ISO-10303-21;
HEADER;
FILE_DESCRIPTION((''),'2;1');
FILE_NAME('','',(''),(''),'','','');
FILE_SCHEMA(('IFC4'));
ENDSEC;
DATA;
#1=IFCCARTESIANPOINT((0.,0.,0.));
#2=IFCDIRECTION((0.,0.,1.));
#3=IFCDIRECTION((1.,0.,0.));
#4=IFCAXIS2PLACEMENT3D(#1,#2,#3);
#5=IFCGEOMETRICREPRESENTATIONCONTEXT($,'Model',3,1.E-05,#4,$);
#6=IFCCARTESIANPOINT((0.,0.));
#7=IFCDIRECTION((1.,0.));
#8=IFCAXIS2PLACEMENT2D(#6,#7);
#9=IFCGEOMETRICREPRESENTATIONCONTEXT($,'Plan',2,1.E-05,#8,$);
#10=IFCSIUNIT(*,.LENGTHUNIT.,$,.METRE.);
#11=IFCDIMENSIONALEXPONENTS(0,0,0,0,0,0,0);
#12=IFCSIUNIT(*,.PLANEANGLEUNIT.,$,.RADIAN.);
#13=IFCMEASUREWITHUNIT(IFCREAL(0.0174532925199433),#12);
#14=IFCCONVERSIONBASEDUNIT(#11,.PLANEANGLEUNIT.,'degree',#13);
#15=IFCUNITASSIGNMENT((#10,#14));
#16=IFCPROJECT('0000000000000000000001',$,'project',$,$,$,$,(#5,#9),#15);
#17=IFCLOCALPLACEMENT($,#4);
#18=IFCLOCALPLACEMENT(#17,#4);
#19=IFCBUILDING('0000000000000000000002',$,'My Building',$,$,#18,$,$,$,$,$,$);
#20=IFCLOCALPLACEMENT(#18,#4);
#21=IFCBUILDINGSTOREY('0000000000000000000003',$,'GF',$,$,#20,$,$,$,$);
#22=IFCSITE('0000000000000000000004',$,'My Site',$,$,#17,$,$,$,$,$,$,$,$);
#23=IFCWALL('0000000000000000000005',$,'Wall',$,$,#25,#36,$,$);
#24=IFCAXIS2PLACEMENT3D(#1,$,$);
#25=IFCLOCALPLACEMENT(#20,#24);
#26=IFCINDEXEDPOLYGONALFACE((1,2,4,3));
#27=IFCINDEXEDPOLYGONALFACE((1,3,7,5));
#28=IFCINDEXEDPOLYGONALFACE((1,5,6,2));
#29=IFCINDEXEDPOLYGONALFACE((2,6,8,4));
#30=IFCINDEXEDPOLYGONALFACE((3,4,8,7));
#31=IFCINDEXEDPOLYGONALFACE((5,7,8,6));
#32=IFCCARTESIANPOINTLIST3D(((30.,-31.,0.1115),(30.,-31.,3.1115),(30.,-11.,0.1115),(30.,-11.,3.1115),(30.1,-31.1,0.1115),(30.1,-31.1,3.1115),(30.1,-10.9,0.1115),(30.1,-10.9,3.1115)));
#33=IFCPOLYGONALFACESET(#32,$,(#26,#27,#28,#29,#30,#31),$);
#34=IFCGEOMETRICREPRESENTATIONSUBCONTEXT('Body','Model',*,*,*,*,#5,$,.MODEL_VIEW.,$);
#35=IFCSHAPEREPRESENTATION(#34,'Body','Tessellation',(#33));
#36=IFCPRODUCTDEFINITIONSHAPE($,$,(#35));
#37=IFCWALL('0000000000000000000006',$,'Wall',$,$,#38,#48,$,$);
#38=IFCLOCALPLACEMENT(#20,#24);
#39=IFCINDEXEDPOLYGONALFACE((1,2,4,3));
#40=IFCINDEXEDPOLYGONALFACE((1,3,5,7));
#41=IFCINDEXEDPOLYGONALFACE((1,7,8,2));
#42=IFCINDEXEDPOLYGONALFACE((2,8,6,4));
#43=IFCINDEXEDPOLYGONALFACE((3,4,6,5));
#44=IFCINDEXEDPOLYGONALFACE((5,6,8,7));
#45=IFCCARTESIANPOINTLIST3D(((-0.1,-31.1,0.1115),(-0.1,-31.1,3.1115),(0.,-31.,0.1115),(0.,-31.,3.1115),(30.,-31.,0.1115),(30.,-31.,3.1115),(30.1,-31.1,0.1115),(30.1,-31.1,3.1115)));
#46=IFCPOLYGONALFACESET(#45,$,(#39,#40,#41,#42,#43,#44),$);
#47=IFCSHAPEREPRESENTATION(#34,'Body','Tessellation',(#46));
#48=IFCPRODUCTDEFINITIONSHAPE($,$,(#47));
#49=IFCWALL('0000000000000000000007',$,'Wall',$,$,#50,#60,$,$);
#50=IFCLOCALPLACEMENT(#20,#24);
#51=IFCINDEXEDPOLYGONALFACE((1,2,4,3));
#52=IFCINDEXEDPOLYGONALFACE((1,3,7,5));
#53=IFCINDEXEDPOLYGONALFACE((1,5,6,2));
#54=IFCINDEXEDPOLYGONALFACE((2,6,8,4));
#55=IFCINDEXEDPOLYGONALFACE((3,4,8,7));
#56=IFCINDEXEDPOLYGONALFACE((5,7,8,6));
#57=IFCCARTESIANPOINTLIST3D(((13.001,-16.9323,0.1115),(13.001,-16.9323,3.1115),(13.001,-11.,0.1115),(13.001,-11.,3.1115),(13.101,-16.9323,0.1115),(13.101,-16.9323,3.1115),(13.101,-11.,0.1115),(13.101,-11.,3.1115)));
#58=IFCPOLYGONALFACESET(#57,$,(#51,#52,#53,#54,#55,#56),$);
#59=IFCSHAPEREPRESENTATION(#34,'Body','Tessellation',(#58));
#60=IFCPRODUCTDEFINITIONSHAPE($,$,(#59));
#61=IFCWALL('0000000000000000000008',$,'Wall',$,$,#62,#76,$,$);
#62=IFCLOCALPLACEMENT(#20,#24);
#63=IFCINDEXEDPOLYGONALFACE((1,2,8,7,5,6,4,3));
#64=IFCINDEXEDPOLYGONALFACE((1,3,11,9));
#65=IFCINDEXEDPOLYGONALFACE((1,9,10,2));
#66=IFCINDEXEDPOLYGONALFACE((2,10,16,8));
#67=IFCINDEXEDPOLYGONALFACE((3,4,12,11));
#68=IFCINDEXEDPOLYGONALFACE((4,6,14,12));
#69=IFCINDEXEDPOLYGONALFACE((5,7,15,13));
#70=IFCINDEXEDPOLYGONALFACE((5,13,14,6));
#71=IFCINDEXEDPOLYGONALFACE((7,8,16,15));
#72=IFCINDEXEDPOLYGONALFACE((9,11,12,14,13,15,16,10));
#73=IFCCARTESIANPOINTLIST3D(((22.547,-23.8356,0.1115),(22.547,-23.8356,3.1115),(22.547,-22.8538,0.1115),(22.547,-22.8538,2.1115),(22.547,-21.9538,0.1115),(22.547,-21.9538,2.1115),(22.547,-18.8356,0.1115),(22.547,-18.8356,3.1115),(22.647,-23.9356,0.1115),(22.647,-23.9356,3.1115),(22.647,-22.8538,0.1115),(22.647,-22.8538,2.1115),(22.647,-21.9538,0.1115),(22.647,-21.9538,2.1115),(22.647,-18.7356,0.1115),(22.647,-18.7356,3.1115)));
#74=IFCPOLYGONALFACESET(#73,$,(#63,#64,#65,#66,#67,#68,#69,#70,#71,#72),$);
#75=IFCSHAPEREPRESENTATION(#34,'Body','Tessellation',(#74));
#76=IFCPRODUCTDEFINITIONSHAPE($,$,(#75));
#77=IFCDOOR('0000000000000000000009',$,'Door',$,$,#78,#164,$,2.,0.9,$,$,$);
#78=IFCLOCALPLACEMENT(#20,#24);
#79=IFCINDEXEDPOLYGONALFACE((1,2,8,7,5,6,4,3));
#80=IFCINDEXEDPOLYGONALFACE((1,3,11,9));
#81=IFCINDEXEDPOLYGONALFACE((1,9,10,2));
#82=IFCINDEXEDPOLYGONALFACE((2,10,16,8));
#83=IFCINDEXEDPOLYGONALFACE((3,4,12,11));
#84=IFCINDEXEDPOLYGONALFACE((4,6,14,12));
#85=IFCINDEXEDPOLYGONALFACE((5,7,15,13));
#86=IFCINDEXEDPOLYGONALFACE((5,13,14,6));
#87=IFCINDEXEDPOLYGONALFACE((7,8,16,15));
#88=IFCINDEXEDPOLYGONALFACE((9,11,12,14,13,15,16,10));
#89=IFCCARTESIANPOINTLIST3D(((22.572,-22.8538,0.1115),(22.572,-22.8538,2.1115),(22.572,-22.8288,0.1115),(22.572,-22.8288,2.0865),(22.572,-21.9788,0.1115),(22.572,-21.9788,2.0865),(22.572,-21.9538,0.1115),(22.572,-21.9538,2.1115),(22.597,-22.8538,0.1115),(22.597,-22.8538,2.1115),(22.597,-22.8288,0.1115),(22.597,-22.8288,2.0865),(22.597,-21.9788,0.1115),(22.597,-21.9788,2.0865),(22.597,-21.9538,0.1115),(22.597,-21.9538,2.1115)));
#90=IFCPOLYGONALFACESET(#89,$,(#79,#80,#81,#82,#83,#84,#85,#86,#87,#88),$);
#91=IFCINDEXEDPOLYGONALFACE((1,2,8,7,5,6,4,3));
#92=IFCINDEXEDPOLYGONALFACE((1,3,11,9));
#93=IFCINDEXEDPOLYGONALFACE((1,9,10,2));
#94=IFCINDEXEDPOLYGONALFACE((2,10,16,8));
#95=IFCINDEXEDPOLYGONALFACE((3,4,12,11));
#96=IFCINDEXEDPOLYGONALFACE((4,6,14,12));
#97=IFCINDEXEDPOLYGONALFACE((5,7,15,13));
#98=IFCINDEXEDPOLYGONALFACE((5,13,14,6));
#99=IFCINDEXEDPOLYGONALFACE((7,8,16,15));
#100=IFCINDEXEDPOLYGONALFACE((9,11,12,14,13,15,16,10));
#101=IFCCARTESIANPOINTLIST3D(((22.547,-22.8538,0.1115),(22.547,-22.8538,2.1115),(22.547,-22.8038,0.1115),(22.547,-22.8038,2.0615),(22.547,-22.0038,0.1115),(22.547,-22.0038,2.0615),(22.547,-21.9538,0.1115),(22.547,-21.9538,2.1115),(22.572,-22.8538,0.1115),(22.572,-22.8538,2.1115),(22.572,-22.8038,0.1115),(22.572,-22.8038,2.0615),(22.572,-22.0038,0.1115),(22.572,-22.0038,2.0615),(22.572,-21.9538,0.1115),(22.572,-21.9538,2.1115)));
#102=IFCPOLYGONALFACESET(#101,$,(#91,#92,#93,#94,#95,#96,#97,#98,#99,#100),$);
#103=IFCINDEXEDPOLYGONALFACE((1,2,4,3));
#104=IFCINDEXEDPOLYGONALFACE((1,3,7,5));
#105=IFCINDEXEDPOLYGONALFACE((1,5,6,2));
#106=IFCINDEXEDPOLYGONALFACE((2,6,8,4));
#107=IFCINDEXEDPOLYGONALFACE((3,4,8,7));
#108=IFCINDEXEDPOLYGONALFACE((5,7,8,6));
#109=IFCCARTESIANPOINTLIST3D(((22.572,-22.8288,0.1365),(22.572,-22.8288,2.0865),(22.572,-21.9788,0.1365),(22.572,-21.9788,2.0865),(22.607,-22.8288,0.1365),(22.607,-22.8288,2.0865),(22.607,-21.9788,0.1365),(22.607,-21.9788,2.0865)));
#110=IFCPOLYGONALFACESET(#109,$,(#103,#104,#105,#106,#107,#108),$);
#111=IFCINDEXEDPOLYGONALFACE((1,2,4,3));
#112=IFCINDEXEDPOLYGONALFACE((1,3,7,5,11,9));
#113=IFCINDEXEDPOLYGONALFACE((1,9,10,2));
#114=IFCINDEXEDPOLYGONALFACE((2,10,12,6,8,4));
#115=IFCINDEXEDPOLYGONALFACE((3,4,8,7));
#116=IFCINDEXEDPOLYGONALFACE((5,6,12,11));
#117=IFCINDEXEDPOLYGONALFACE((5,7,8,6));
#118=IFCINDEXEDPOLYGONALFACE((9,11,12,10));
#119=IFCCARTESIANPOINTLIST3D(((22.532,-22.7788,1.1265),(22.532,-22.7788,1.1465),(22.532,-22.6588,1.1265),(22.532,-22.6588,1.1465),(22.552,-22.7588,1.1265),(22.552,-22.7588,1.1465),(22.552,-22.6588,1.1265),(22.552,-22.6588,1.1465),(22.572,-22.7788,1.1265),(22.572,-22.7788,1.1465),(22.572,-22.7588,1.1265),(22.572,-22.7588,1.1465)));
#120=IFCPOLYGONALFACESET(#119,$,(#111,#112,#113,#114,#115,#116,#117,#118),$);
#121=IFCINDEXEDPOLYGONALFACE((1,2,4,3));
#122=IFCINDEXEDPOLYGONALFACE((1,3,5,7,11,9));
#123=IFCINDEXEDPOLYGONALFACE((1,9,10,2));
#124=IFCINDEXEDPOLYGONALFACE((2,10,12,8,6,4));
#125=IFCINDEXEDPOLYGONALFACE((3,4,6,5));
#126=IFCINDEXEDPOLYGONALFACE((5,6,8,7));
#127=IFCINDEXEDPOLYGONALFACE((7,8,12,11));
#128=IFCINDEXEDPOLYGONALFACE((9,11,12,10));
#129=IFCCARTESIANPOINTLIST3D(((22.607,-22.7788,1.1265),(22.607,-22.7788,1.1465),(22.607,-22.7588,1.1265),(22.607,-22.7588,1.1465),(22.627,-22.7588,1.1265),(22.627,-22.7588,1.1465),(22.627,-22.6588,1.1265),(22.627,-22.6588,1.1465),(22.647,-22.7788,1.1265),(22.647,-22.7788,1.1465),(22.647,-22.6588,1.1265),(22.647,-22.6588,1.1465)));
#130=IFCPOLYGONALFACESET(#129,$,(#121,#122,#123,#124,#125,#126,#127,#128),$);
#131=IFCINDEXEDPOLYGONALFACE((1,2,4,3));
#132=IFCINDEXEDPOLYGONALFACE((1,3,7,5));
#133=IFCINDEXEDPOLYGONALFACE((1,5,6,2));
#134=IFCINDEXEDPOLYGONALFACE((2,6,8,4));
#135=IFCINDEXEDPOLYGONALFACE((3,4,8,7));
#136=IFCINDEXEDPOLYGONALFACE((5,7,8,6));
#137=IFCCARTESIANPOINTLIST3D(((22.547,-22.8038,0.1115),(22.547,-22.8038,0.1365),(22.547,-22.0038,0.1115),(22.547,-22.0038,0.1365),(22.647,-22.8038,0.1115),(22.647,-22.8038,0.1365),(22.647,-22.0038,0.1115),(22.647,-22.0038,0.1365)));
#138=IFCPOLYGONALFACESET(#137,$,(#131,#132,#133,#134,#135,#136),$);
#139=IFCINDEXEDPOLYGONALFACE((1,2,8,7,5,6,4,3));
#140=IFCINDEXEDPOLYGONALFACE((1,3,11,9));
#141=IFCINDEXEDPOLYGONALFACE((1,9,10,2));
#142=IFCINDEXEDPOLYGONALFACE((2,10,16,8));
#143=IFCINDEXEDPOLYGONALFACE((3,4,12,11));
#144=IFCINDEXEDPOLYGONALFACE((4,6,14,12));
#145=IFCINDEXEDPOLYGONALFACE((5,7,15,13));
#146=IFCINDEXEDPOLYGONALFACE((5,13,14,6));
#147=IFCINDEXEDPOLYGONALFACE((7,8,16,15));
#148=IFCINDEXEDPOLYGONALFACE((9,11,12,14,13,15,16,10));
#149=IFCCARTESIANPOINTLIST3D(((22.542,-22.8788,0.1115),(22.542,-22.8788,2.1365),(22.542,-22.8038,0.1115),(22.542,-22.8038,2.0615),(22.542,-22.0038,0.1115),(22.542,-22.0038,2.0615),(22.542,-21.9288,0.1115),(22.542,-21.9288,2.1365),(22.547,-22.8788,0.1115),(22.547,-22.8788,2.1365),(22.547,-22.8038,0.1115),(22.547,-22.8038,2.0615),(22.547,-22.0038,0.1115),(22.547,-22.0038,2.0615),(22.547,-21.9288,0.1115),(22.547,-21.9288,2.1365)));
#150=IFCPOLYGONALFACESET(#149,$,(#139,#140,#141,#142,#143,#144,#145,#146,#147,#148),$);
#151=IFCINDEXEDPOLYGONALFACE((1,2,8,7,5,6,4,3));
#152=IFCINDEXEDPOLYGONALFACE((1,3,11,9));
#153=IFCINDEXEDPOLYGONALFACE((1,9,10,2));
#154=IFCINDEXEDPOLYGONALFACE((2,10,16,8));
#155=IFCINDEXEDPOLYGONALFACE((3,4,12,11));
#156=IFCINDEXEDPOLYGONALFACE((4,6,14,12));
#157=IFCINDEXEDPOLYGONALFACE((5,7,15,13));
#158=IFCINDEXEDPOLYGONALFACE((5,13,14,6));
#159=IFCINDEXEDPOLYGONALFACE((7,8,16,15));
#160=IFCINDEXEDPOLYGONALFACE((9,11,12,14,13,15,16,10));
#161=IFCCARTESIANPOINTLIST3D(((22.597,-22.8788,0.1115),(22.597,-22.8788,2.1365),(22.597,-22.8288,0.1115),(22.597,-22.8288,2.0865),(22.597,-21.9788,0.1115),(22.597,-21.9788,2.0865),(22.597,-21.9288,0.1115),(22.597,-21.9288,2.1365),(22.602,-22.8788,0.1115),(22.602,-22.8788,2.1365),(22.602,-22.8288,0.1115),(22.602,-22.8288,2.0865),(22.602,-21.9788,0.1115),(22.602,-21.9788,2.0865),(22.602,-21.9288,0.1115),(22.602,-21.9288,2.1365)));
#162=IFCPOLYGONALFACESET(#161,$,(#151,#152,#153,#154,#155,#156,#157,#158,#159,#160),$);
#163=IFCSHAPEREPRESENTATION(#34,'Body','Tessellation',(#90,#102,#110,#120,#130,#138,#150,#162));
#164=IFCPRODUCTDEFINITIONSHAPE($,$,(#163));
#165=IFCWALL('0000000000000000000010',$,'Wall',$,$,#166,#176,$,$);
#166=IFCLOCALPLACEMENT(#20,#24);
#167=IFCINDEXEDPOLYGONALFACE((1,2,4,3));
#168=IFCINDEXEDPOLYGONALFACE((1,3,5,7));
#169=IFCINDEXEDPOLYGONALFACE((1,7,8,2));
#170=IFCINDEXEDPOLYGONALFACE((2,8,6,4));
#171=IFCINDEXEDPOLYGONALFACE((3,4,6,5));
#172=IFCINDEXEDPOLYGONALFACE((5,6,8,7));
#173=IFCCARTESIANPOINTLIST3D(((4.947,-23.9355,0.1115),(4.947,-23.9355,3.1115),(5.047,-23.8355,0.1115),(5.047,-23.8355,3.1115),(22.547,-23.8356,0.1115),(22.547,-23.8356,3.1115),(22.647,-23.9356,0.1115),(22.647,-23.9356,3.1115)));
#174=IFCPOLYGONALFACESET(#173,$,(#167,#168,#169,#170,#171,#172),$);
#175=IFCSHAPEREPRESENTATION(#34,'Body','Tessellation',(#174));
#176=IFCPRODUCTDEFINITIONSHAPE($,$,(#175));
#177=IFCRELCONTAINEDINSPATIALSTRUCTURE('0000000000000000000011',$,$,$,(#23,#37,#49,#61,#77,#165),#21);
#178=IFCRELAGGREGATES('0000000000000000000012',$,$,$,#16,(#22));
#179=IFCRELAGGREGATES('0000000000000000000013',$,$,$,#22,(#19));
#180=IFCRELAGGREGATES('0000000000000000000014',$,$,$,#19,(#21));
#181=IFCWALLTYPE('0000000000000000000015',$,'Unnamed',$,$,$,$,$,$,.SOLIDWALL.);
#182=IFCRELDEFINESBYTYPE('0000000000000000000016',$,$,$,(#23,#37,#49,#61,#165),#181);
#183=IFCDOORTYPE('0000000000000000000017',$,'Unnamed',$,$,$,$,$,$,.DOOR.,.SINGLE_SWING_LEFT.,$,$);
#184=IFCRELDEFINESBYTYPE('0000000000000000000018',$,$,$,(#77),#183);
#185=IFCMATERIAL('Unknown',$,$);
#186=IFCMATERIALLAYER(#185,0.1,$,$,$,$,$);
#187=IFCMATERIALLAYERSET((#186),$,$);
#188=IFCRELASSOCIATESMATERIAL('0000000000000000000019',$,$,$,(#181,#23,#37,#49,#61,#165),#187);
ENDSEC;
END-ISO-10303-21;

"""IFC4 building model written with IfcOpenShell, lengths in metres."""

from ifc_helpers import new_model, entity, si_unit, converted_unit, frame, origin_with_axes, origin_2d_with_axis, place, context, subcontext, project, spatial, line, indexed_curve, outline, extrude, shape, source, transform, mapped, material, layer, layer_set, layer_usage, type_object, type_shapes, element, fill, save


model = new_model("IFC4")

# Units and contexts
model_context = context("Model", 3, precision=1e-05, world=origin_with_axes())
plan_context = context("Plan", 2, precision=1e-05, world=origin_2d_with_axis())
body_context_1 = subcontext(model_context, "Body", "Model", "MODEL_VIEW")
body_context_2 = subcontext(plan_context, "Body", "Plan", "PLAN_VIEW")
ifc_project = project(units=[si_unit("LENGTHUNIT", "METRE"), converted_unit("PLANEANGLEUNIT", "degree", entity("IfcReal", 0.0174532925199433), si_unit("PLANEANGLEUNIT", "RADIAN"), dimensions=[0, 0, 0, 0, 0, 0, 0])], contexts=[model_context, plan_context])

# Site, building, storey
site_placement = place(None, origin_with_axes())
site = spatial("IfcSite", under=ifc_project, at=site_placement, Name="My Site")
building_placement = place(site_placement, origin_with_axes())
building = spatial("IfcBuilding", under=site, at=building_placement, Name="My Building")
storey_placement = place(building_placement, origin_with_axes())
storey = spatial("IfcBuildingStorey", under=building, at=storey_placement, Name="GF")

# Walls
ifc_material = material(Name="Unknown")
ifc_layer = layer(ifc_material, 0.1)
ifc_layer_set = layer_set([ifc_layer])
ifc_layer_usage_1 = layer_usage(ifc_layer_set, "AXIS2", "POSITIVE", 0.0)
wall_type = type_object("IfcWallType", Name="Unnamed", PredefinedType="SOLIDWALL", material=ifc_layer_set)
wall_1_placement = place(storey_placement, frame((30.0, -11.0, 0.1115), z_axis=(0.0, 0.0, 1.0), x_axis=(0.0, -1.0, 0.0)))
element("IfcWall", 1, at=wall_1_placement, inside=storey, type_object=wall_type, material=ifc_layer_usage_1, Name="Wall", context=body_context_1, shape_type="SweptSolid", body=[
    extrude(outline(indexed_curve([(0.0, 0.0), (-0.1, 0.1), (20.1, 0.1), (20.0, 0.0)], segments=[line(1, 2, 3, 4, 1)])), origin_with_axes(), (0.0, 0.0, 1.0), 3.0),
])
ifc_layer_usage_2 = layer_usage(ifc_layer_set, "AXIS2", "POSITIVE", 0.0)
wall_2_placement = place(storey_placement, frame((30.0, -31.0, 0.1115), z_axis=(0.0, 0.0, 1.0), x_axis=(-1.0, 0.0, 0.0)))
element("IfcWall", 2, at=wall_2_placement, inside=storey, type_object=wall_type, material=ifc_layer_usage_2, Name="Wall", context=body_context_1, shape_type="SweptSolid", body=[
    extrude(outline(indexed_curve([(0.0, 0.0), (-0.1, 0.1), (30.1, 0.1), (30.0, 0.0)], segments=[line(1, 2, 3, 4, 1)])), origin_with_axes(), (0.0, 0.0, 1.0), 3.0),
])
ifc_layer_usage_3 = layer_usage(ifc_layer_set, "AXIS2", "POSITIVE", 0.0)
wall_3_placement = place(storey_placement, frame((13.101, -16.9323, 0.1115), z_axis=(0.0, 0.0, 1.0), x_axis=(0.0, 1.0, 0.0)))
element("IfcWall", 3, at=wall_3_placement, inside=storey, type_object=wall_type, material=ifc_layer_usage_3, Name="Wall", context=body_context_1, shape_type="SweptSolid", body=[
    extrude(outline(indexed_curve([(0.0, 0.0), (0.0, 0.1), (5.9323, 0.1), (5.9323, 0.0)], segments=[line(1, 2, 3, 4, 1)])), origin_with_axes(), (0.0, 0.0, 1.0), 3.0),
])

# Wall, opening, door
ifc_layer_usage_4 = layer_usage(ifc_layer_set, "AXIS2", "POSITIVE", 0.0)
wall_4_placement = place(storey_placement, frame((22.547, -18.8356, 0.1115), z_axis=(0.0, 0.0, 1.0), x_axis=(0.0, -1.0, 0.0)))
wall_4 = element("IfcWall", 4, at=wall_4_placement, inside=storey, type_object=wall_type, material=ifc_layer_usage_4, Name="Wall", context=body_context_1, shape_type="SweptSolid", body=[
    extrude(outline(indexed_curve([(0.0, 0.0), (-0.1, 0.1), (5.1, 0.1), (5.0, 0.0)], segments=[line(1, 2, 3, 4, 1)])), origin_with_axes(), (0.0, 0.0, 1.0), 3.0),
])
shared_shape_1 = source(origin_with_axes(), body_context_1, "Body", "SweptSolid", [
    extrude(outline(indexed_curve([(0.0, 0.0), (0.9, 0.0), (0.9, 2.0), (0.0, 2.0)], segments=[line(1, 2, 3, 4, 1)])), frame((0.0, -0.6, 0.0), z_axis=(0.0, -1.0, 0.0), x_axis=(1.0, 0.0, 0.0)), (0.0, 0.0, -1.0), 1.2),
])
opening_1_placement = place(wall_4_placement, frame((3.1182, 0.0, 0.0), z_axis=(0.0, 0.0, 1.0), x_axis=(1.0, 0.0, 0.0)))
opening_1 = element("IfcOpeningElement", 5, at=opening_1_placement, cuts=wall_4, PredefinedType="OPENING", context=body_context_1, shape_type="MappedRepresentation", body=[
    mapped(shared_shape_1, transform((0.0, 0.0, 0.0), x_axis=(1.0, 0.0, 0.0), y_axis=(0.0, 1.0, 0.0), z_axis=(0.0, 0.0, 1.0), scale=1.0)),
])
door_type = type_object("IfcDoorType", Name="Unnamed", OperationType="SINGLE_SWING_LEFT", PredefinedType="DOOR")
shared_shape_2 = source(origin_with_axes(), body_context_1, "Body", "SweptSolid", [
    extrude(outline(indexed_curve([(0.0, 0.0), (0.0, 2.0), (0.9, 2.0), (0.9, 0.0), (0.875, 0.0), (0.875, 1.975), (0.025, 1.975), (0.025, 0.0)], segments=[line(1, 2, 3, 4, 5, 6, 7, 8, 1)])), frame((0.0, 0.025, 0.0), z_axis=(0.0, -1.0, 0.0), x_axis=(1.0, 0.0, 0.0)), (0.0, 0.0, -1.0), 0.025),
    extrude(outline(indexed_curve([(0.0, 0.0), (0.0, 2.0), (0.9, 2.0), (0.9, 0.0), (0.85, 0.0), (0.85, 1.95), (0.05, 1.95), (0.05, 0.0)], segments=[line(1, 2, 3, 4, 5, 6, 7, 8, 1)])), frame((0.0, 0.0, 0.0), z_axis=(0.0, -1.0, 0.0), x_axis=(1.0, 0.0, 0.0)), (0.0, 0.0, -1.0), 0.025),
    extrude(outline(indexed_curve([(0.0, 0.0), (0.85, 0.0), (0.85, 0.035), (0.0, 0.035)], segments=[line(1, 2, 3, 4, 1)])), frame((0.025, 0.025, 0.025), z_axis=(0.0, 0.0, 1.0), x_axis=(1.0, 0.0, 0.0)), (0.0, 0.0, 1.0), 1.95),
    extrude(outline(indexed_curve([(0.0, 0.0), (0.0, -0.04), (-0.12, -0.04), (-0.12, -0.02), (-0.02, -0.02), (-0.02, 0.0)], segments=[line(1, 2, 3, 4, 5, 6, 1)])), frame((0.825, 0.025, 1.015), z_axis=(0.0, 0.0, 1.0), x_axis=(1.0, 0.0, 0.0)), (0.0, 0.0, 1.0), 0.02),
    extrude(outline(indexed_curve([(0.0, 0.0), (0.0, 0.04), (-0.12, 0.04), (-0.12, 0.02), (-0.02, 0.02), (-0.02, 0.0)], segments=[line(1, 2, 3, 4, 5, 6, 1)])), frame((0.825, 0.06, 1.015), z_axis=(0.0, 0.0, 1.0), x_axis=(1.0, 0.0, 0.0)), (0.0, 0.0, 1.0), 0.02),
    extrude(outline(indexed_curve([(0.0, 0.0), (0.8, 0.0), (0.8, 0.1), (0.0, 0.1)], segments=[line(1, 2, 3, 4, 1)])), frame((0.05, 0.0, 0.0), z_axis=(0.0, 0.0, 1.0), x_axis=(1.0, 0.0, 0.0)), (0.0, 0.0, 1.0), 0.025),
    extrude(outline(indexed_curve([(0.0, 0.0), (0.0, 2.025), (0.95, 2.025), (0.95, 0.0), (0.875, 0.0), (0.875, 1.95), (0.075, 1.95), (0.075, 0.0)], segments=[line(1, 2, 3, 4, 5, 6, 7, 8, 1)])), frame((-0.025, -0.005, 0.0), z_axis=(0.0, -1.0, 0.0), x_axis=(1.0, 0.0, 0.0)), (0.0, 0.0, -1.0), 0.005),
    extrude(outline(indexed_curve([(0.0, 0.0), (0.0, 2.025), (0.95, 2.025), (0.95, 0.0), (0.9, 0.0), (0.9, 1.975), (0.05, 1.975), (0.05, 0.0)], segments=[line(1, 2, 3, 4, 5, 6, 7, 8, 1)])), frame((-0.025, 0.05, 0.0), z_axis=(0.0, -1.0, 0.0), x_axis=(1.0, 0.0, 0.0)), (0.0, 0.0, -1.0), 0.005),
])
shared_shape_3 = source(origin_with_axes(), body_context_2, "Body", "Curve2D", [
    entity("IfcIndexedPolyCurve", entity("IfcCartesianPointList2D", [[0.0, 0.0], [0.0, 0.05], [0.025, 0.05], [0.025, 0.025], [0.05, 0.025], [0.05, 0.0]]), [entity("IfcLineIndex", [1, 2, 3, 4, 5, 6, 1])]),
    entity("IfcIndexedPolyCurve", entity("IfcCartesianPointList2D", [[0.9, 0.0], [0.9, 0.05], [0.875, 0.05], [0.875, 0.025], [0.85, 0.025], [0.85, 0.0]]), [entity("IfcLineIndex", [1, 2, 3, 4, 5, 6, 1])]),
    entity("IfcTrimmedCurve", entity("IfcEllipse", entity("IfcAxis2Placement2D", entity("IfcCartesianPoint", [0.06, 0.05]), entity("IfcDirection", [1.0, 0.0])), 0.815, 0.85), [entity("IfcCartesianPoint", [0.875, 0.05])], [entity("IfcCartesianPoint", [0.06, 0.9])], True, "CARTESIAN"),
    entity("IfcIndexedPolyCurve", entity("IfcCartesianPointList2D", [[0.025, 0.05], [0.06, 0.05], [0.06, 0.9], [0.025, 0.9]]), [entity("IfcLineIndex", [1, 2, 3, 4, 1])]),
])
type_shapes(door_type, [shared_shape_2, shared_shape_3])
door_1_placement = place(opening_1_placement, frame((0.0, 0.0, 0.0), z_axis=(0.0, 0.0, 1.0), x_axis=(1.0, 0.0, 0.0)))
door_1 = element("IfcDoor", 6, at=door_1_placement, inside=storey, type_object=door_type, Name="Door", OverallHeight=2.0, OverallWidth=0.9, shapes=[
    shape(body_context_1, "Body", "MappedRepresentation", [mapped(shared_shape_2, transform((0.0, 0.0, 0.0), x_axis=(1.0, 0.0, 0.0), y_axis=(0.0, 1.0, 0.0), z_axis=(0.0, 0.0, 1.0), scale=1.0))]),
    shape(body_context_2, "Body", "MappedRepresentation", [mapped(shared_shape_3, transform((0.0, 0.0, 0.0), x_axis=(1.0, 0.0, 0.0), y_axis=(0.0, 1.0, 0.0), z_axis=(0.0, 0.0, 1.0), scale=1.0))]),
])
fill(opening_1, door_1)

# Wall
ifc_layer_usage_5 = layer_usage(ifc_layer_set, "AXIS2", "POSITIVE", 0.0)
wall_5_placement = place(storey_placement, frame((22.547, -23.8356, 0.1115), z_axis=(0.0, 0.0, 1.0), x_axis=(-1.0, 0.0, 0.0)))
element("IfcWall", 7, at=wall_5_placement, inside=storey, type_object=wall_type, material=ifc_layer_usage_5, Name="Wall", context=body_context_1, shape_type="SweptSolid", body=[
    extrude(outline(indexed_curve([(0.0, 0.0), (-0.1, 0.1), (17.6, 0.1), (17.5, 0.0)], segments=[line(1, 2, 3, 4, 1)])), origin_with_axes(), (0.0, 0.0, 1.0), 3.0),
])

save(model, "model.ifc")
